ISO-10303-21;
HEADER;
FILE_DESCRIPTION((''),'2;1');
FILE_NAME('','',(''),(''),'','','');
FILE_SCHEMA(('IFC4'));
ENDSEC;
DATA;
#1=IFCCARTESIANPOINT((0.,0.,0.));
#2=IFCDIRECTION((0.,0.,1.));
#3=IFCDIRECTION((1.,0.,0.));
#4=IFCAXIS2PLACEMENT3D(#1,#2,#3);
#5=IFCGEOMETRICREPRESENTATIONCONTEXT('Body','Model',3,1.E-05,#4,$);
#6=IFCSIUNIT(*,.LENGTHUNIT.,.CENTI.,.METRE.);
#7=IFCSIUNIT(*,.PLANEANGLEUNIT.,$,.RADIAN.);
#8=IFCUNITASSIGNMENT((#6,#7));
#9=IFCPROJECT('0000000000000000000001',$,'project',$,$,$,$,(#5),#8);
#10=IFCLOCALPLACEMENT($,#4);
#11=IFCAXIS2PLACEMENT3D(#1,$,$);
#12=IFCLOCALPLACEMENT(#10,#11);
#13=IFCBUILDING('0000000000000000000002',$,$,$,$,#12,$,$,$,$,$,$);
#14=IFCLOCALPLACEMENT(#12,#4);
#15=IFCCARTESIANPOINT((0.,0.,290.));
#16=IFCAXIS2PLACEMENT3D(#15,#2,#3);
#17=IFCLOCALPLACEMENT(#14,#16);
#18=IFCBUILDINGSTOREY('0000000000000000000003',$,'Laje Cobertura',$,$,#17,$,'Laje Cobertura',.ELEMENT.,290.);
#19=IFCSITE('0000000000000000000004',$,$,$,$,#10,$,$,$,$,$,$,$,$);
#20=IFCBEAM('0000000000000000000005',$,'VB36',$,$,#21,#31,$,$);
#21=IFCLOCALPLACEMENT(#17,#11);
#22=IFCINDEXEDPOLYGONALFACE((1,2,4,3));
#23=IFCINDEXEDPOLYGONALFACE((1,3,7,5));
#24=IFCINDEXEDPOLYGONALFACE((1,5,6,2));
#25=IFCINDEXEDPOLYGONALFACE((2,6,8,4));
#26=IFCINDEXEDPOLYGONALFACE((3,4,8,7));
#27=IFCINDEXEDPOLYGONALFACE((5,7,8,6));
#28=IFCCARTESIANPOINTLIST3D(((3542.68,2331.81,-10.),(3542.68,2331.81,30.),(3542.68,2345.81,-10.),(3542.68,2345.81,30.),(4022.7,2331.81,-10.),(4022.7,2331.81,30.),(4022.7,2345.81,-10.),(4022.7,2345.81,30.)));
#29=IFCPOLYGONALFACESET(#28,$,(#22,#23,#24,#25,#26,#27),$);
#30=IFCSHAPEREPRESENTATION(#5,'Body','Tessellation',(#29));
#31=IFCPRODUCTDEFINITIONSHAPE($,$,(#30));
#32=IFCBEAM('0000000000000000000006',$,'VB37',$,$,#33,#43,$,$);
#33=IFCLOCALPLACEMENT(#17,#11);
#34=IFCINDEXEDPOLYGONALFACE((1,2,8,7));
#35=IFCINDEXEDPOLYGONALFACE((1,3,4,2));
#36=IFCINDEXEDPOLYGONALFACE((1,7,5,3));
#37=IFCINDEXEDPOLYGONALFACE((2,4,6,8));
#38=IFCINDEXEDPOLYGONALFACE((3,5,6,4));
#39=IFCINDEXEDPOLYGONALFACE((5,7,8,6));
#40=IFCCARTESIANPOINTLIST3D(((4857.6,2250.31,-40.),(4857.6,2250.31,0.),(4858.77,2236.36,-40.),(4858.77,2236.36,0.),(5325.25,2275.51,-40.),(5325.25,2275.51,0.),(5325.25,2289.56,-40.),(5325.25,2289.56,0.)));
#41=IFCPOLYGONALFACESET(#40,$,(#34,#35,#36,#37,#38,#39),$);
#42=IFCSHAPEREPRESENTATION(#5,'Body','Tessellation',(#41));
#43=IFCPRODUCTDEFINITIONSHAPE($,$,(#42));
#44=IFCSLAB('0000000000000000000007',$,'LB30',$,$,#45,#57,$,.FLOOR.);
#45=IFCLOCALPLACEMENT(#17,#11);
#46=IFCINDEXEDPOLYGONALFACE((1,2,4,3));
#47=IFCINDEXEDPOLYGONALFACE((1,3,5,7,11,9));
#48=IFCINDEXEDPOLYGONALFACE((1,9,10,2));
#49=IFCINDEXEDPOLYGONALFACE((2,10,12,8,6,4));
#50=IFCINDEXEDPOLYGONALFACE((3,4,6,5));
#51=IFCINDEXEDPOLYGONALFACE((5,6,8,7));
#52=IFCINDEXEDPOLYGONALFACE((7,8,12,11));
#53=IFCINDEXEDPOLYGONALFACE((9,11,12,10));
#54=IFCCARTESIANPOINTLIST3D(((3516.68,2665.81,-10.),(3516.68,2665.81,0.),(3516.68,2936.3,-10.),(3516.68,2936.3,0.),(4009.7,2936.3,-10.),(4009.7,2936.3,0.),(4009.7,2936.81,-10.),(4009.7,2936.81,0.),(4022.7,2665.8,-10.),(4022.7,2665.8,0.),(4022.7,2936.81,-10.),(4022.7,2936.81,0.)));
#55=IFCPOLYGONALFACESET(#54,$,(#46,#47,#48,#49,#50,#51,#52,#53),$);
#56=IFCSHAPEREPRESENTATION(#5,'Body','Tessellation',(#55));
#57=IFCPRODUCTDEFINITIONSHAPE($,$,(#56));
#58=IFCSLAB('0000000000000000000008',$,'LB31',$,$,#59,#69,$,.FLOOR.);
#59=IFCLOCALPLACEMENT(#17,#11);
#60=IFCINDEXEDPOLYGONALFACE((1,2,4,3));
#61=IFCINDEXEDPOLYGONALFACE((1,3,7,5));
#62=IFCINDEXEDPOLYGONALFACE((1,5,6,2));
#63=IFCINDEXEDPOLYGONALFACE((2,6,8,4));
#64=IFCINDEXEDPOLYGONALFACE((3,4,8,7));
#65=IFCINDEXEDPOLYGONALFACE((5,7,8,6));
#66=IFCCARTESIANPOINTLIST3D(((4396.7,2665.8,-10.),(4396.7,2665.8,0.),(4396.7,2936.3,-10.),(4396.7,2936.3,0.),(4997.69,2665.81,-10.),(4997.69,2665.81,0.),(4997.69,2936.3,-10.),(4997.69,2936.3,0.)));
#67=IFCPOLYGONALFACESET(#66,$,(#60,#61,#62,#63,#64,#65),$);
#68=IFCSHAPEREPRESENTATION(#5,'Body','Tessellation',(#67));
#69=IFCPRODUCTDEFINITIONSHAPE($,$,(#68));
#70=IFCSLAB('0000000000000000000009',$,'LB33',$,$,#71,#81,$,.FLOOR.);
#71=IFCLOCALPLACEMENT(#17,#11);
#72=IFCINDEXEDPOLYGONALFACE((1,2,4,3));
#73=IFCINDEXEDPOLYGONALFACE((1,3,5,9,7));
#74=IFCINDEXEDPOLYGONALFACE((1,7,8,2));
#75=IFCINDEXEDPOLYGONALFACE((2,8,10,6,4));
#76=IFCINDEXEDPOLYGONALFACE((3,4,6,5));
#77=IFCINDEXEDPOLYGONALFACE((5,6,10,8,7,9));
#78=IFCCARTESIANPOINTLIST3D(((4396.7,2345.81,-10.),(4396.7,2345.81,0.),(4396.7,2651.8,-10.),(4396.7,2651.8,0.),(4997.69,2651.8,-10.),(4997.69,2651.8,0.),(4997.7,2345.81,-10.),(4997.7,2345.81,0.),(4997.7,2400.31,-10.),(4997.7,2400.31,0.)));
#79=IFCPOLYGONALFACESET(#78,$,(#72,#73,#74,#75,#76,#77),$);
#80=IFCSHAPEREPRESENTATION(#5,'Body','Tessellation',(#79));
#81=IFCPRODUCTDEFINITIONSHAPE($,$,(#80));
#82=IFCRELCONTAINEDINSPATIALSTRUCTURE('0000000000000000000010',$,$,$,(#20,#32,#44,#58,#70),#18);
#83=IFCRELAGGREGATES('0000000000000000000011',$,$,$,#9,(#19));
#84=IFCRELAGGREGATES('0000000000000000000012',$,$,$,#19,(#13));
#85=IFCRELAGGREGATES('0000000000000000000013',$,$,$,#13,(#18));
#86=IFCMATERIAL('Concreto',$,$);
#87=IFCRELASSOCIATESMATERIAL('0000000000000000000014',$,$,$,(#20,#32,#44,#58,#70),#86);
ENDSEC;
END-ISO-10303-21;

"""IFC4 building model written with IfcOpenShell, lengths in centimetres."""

from ifc_helpers import new_model, si_unit, frame, origin, origin_with_axes, origin_2d_with_axis, place, context, project, spatial, polyline, rectangle, outline, extrude, clip, halfspace, material, element, save


model = new_model("IFC4")

# Units and contexts
model_context = context("Model", 3, precision=1e-05, world=origin_with_axes(), identifier="Body")
ifc_project = project(units=[si_unit("LENGTHUNIT", "METRE", prefix="CENTI"), si_unit("PLANEANGLEUNIT", "RADIAN")], contexts=[model_context])

# Site, building, storey
site_placement = place(None, origin_with_axes())
site = spatial("IfcSite", under=ifc_project, at=site_placement)
building_placement = place(site_placement, origin())
building = spatial("IfcBuilding", under=site, at=building_placement)
placement = place(building_placement, origin_with_axes())
storey_placement = place(placement, frame((0.0, 0.0, 290.0), z_axis=(0.0, 0.0, 1.0), x_axis=(1.0, 0.0, 0.0)))
storey = spatial("IfcBuildingStorey", under=building, at=storey_placement, Name="Laje Cobertura", LongName="Laje Cobertura", CompositionType="ELEMENT", Elevation=290.0)

# Shared definitions
ifc_material = material(Name="Concreto")

# Beams
beam_1_placement = place(storey_placement, frame((3782.69, 2338.81, 30.0), z_axis=(0.0, 0.0, 1.0), x_axis=(1.0, 0.0, 0.0)))
element("IfcBeam", 1, at=beam_1_placement, inside=storey, material=ifc_material, Name="VB36", context=model_context, shape_type="SolidModel", body=[
    extrude(rectangle(XDim=14.0, YDim=40.0, at=origin_2d_with_axis()), frame((-240.01, 0.0, -20.0), z_axis=(1.0, 0.0, 0.0), x_axis=(0.0, 1.0, 0.0)), (0.0, 0.0, 1.0), 480.02),
])
beam_2_placement = place(storey_placement, frame((5091.42, 2262.96, 0.0), z_axis=(0.0, 0.0, 1.0), x_axis=(1.0, 0.0, 0.0)))
element("IfcBeam", 2, at=beam_2_placement, inside=storey, material=ifc_material, Name="VB37", context=model_context, shape_type="Clipping", body=[
    clip(extrude(rectangle(XDim=14.0, YDim=40.0, at=origin_2d_with_axis()), frame((-233.24, -19.63, -20.0), z_axis=(0.996496, 0.083638, 0.0), x_axis=(-0.083638, 0.996496, 0.0)), (0.0, 0.0, 1.0), 469.3), halfspace(frame((233.83, 26.6, -40.0), z_axis=(-1.0, 0.0, 0.0), x_axis=(0.0, 0.0, -0.083638)), True)),
])

# Slabs
slab_1_placement = place(storey_placement, frame((3769.69, 2801.31, 0.0), z_axis=(0.0, 0.0, 1.0), x_axis=(1.0, 0.0, 0.0)))
element("IfcSlab", 3, at=slab_1_placement, inside=storey, material=ifc_material, Name="LB30", PredefinedType="FLOOR", context=model_context, shape_type="SolidModel", body=[
    extrude(outline(polyline([(253.01, 135.5), (240.01, 135.5), (240.01, 135.0), (-253.01, 134.99), (-253.01, -135.5), (253.01, -135.5), (253.01, 135.5), (253.01, 135.5)])), frame((0.0, 0.0, -10.0), z_axis=(0.0, 0.0, 1.0), x_axis=(1.0, 0.0, 0.0)), (0.0, 0.0, 1.0), 10.0),
])
slab_2_placement = place(storey_placement, frame((4697.19, 2801.05, 0.0), z_axis=(0.0, 0.0, 1.0), x_axis=(1.0, 0.0, 0.0)))
element("IfcSlab", 4, at=slab_2_placement, inside=storey, material=ifc_material, Name="LB31", PredefinedType="FLOOR", context=model_context, shape_type="SolidModel", body=[
    extrude(outline(polyline([(300.49, -135.24), (300.49, 135.25), (-300.49, 135.25), (-300.5, -135.25), (300.49, -135.24), (300.49, -135.24)])), frame((0.0, 0.0, -10.0), z_axis=(0.0, 0.0, 1.0), x_axis=(1.0, 0.0, 0.0)), (0.0, 0.0, 1.0), 10.0),
])
slab_3_placement = place(storey_placement, frame((4697.2, 2498.8, 0.0), z_axis=(0.0, 0.0, 1.0), x_axis=(1.0, 0.0, 0.0)))
element("IfcSlab", 5, at=slab_3_placement, inside=storey, material=ifc_material, Name="LB33", PredefinedType="FLOOR", context=model_context, shape_type="SolidModel", body=[
    extrude(outline(polyline([(300.5, -152.99), (300.5, -98.5), (300.49, 153.0), (-300.5, 153.0), (-300.5, -153.0), (300.5, -152.99), (300.5, -152.99)])), frame((0.0, 0.0, -10.0), z_axis=(0.0, 0.0, 1.0), x_axis=(1.0, 0.0, 0.0)), (0.0, 0.0, 1.0), 10.0),
])

save(model, "model.ifc")
